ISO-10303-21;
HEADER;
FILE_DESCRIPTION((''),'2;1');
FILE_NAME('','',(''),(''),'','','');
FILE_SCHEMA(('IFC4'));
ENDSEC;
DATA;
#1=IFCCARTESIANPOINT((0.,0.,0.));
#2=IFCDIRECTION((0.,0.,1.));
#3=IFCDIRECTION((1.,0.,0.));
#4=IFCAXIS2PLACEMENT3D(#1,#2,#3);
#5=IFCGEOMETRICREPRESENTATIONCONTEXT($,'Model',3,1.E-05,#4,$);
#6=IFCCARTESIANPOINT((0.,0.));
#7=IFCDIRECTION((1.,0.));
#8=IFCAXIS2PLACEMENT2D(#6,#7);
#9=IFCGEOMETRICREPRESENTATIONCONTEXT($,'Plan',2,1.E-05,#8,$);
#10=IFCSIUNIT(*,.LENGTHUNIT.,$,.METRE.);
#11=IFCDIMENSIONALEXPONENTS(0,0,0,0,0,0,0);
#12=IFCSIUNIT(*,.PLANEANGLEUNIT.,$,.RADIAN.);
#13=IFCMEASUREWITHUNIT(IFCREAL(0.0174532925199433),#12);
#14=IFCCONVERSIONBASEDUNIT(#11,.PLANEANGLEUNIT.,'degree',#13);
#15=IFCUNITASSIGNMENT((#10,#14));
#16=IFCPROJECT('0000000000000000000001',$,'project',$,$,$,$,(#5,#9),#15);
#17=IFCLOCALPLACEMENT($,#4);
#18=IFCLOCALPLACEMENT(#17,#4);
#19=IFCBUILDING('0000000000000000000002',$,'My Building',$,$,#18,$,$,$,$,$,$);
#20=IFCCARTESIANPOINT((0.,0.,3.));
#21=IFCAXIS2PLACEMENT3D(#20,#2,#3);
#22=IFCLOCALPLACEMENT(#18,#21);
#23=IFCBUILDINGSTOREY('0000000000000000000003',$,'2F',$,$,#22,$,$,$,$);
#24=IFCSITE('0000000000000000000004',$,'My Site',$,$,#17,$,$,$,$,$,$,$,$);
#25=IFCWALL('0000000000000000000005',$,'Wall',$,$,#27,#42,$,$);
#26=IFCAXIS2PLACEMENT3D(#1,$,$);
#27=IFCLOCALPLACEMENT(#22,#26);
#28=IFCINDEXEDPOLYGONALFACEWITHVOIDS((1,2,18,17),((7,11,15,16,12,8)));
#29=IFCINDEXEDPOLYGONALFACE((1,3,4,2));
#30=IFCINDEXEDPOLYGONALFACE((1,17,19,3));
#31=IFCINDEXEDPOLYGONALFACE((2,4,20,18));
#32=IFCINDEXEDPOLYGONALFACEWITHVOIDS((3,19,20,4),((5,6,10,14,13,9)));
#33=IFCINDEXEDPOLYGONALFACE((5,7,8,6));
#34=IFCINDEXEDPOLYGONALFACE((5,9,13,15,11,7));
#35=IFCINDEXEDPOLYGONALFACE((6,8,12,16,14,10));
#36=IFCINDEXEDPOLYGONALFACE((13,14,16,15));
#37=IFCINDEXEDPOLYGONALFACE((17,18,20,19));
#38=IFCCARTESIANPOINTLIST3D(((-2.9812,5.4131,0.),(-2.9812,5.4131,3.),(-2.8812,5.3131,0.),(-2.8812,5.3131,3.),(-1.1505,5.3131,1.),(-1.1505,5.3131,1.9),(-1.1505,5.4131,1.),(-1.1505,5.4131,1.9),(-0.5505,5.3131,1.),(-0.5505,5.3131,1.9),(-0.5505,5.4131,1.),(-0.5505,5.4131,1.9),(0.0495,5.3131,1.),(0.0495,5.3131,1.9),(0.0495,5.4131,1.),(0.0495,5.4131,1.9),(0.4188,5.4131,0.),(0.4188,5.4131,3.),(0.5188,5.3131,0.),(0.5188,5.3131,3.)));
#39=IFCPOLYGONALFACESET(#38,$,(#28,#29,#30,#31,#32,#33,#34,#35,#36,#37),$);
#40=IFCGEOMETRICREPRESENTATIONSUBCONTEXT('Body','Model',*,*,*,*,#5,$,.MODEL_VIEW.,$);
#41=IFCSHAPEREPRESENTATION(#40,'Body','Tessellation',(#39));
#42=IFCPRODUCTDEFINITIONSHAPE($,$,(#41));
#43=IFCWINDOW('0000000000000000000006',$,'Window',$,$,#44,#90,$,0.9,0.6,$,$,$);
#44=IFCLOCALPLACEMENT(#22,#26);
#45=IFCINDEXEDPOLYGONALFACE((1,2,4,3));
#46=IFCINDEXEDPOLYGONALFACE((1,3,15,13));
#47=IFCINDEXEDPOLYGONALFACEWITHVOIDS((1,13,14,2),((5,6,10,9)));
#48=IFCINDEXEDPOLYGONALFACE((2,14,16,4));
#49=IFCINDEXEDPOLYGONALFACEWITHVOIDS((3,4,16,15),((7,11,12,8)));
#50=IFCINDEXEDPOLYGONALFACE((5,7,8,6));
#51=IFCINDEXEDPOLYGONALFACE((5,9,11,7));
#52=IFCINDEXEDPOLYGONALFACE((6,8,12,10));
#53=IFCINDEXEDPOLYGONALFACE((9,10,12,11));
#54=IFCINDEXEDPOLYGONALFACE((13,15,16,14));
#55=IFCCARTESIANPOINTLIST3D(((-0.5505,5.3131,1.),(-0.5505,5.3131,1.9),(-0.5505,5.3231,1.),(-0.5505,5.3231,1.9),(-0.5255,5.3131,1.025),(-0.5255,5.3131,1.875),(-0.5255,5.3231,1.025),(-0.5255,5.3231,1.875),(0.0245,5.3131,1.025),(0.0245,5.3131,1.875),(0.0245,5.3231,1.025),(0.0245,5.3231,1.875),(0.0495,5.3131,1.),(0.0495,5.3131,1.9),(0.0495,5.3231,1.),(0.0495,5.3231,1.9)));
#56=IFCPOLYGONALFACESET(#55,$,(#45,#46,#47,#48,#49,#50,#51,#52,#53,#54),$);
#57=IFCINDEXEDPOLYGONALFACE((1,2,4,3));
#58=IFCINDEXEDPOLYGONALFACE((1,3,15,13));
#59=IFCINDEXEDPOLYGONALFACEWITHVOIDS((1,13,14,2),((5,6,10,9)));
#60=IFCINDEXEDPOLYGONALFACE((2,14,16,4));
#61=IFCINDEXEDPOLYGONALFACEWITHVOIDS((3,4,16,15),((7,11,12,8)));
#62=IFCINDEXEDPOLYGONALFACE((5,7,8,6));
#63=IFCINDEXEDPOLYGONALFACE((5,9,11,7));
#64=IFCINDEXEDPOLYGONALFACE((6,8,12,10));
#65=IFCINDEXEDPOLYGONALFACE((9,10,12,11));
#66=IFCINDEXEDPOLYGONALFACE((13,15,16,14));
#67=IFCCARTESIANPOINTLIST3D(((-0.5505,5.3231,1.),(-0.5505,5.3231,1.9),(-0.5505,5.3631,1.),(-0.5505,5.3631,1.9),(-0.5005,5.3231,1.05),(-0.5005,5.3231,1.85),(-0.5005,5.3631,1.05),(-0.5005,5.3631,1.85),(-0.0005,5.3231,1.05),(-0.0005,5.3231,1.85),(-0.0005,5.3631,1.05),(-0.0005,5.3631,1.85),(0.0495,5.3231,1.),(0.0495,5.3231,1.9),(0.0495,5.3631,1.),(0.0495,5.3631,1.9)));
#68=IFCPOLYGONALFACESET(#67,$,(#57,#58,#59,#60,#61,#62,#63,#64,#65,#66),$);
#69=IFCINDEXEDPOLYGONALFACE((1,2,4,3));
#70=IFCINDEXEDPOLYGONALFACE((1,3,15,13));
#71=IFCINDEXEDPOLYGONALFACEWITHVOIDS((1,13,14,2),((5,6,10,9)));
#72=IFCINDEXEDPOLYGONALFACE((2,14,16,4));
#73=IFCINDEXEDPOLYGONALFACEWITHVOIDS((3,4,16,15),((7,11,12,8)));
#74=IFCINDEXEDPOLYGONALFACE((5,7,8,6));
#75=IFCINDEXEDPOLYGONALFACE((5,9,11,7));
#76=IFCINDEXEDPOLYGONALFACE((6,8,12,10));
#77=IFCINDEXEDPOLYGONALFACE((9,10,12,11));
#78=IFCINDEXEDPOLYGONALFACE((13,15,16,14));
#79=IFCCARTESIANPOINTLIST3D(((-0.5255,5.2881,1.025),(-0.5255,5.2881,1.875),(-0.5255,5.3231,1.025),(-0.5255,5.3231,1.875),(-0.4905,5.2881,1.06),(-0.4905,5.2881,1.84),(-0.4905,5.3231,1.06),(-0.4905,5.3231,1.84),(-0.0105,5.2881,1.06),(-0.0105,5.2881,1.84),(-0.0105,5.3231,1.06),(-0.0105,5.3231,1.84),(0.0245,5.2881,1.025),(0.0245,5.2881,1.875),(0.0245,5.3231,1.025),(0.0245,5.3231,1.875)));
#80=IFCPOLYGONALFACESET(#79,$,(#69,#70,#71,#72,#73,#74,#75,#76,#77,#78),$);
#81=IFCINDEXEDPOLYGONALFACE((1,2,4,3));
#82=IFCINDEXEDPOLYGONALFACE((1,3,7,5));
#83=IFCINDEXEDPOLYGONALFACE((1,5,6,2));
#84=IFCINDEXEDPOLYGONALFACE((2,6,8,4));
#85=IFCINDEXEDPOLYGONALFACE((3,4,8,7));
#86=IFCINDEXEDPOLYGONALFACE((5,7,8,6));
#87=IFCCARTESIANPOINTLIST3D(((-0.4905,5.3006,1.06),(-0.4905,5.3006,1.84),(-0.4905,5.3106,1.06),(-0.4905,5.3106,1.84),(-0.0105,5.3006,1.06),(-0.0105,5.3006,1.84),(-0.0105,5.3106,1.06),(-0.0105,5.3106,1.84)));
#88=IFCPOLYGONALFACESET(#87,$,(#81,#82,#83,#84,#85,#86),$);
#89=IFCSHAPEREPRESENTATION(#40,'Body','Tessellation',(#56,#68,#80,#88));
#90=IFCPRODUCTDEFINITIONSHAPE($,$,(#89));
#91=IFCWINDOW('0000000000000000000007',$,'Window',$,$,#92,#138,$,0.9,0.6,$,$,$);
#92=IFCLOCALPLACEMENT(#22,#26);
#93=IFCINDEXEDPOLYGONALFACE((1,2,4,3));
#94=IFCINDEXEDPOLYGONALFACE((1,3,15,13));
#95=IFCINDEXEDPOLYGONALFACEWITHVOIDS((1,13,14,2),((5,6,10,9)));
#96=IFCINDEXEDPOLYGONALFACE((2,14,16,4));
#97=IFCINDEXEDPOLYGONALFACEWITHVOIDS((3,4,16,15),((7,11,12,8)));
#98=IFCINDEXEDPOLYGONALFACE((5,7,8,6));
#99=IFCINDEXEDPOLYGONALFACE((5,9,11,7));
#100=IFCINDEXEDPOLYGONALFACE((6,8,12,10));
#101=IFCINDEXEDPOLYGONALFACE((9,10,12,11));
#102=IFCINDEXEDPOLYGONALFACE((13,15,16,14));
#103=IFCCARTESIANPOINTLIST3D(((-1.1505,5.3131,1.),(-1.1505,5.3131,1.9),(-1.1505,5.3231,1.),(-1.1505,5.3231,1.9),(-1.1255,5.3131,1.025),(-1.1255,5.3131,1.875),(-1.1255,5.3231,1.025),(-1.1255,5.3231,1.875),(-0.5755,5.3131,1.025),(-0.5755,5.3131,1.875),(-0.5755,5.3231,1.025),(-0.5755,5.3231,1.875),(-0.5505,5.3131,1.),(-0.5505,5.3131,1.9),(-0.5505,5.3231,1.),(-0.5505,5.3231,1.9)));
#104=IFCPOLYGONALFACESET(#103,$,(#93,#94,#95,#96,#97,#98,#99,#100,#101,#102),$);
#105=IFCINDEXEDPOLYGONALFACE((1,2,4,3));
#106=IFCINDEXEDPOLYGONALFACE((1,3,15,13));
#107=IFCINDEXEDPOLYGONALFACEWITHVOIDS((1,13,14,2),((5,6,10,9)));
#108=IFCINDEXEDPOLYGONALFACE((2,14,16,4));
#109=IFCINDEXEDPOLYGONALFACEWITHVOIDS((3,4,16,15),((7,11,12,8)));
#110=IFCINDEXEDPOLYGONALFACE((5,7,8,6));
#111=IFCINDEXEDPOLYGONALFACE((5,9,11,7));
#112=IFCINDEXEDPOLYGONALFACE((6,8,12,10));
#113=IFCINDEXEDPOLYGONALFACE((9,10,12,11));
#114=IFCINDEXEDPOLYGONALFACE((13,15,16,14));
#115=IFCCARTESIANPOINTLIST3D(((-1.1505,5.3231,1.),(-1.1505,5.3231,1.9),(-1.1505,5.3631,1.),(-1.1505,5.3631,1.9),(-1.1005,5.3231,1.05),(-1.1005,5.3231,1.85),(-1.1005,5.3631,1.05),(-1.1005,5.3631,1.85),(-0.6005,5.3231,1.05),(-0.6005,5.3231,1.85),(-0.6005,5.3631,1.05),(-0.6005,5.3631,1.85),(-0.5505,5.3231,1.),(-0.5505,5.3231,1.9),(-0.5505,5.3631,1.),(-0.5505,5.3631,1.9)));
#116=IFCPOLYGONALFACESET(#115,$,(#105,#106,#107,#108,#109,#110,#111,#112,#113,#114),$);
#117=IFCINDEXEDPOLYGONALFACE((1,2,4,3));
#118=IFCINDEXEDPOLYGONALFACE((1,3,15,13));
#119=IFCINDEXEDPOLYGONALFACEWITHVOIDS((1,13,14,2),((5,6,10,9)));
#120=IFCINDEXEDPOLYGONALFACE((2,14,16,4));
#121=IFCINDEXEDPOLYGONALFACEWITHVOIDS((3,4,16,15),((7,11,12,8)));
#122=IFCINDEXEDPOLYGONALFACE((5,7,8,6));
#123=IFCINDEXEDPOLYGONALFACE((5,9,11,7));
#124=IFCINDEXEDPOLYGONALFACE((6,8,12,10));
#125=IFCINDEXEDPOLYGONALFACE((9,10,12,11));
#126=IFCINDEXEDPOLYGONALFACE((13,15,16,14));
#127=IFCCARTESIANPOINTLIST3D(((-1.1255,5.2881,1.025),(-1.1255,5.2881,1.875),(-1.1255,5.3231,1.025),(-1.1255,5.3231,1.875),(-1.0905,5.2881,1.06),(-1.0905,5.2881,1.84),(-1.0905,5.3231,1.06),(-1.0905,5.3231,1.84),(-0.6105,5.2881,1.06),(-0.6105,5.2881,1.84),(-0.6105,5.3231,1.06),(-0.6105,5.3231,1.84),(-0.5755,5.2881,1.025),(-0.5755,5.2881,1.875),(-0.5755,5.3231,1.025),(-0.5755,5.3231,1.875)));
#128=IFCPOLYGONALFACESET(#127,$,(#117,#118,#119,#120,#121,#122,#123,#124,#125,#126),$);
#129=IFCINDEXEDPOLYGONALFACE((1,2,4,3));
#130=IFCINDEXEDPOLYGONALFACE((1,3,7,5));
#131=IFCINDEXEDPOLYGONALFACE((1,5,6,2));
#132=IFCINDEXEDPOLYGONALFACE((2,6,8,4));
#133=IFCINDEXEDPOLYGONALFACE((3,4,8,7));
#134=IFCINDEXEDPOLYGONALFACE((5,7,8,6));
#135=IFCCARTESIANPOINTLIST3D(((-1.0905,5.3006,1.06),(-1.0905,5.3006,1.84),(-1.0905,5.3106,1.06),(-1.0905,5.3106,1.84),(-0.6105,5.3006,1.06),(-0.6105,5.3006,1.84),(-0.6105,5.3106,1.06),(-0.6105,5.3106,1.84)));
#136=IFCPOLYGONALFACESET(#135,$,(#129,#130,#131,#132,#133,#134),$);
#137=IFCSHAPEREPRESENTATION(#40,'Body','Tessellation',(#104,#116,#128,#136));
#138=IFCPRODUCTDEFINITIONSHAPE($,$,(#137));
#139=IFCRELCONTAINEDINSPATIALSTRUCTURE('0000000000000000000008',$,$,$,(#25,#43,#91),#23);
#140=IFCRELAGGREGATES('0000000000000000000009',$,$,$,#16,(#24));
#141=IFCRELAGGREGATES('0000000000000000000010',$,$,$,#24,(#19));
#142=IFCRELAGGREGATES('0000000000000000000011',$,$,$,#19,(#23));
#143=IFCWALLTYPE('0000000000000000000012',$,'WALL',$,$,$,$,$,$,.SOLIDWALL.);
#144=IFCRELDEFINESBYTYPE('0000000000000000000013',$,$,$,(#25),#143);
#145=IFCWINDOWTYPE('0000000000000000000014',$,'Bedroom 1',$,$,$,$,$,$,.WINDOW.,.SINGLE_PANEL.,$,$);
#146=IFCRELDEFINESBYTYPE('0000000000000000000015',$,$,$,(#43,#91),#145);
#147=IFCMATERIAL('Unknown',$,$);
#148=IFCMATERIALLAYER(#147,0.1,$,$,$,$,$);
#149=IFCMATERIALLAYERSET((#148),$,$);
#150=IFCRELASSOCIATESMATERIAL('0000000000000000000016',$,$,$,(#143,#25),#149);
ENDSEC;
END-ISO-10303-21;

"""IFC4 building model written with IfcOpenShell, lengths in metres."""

from ifc_helpers import new_model, entity, si_unit, converted_unit, frame, origin_with_axes, origin_2d_with_axis, place, context, subcontext, project, spatial, line, indexed_curve, outline, extrude, shape, source, transform, mapped, material, layer, layer_set, layer_usage, type_object, type_shapes, element, fill, save


model = new_model("IFC4")

# Units and contexts
model_context = context("Model", 3, precision=1e-05, world=origin_with_axes())
plan_context = context("Plan", 2, precision=1e-05, world=origin_2d_with_axis())
body_context_1 = subcontext(model_context, "Body", "Model", "MODEL_VIEW")
body_context_2 = subcontext(plan_context, "Body", "Plan", "PLAN_VIEW")
ifc_project = project(units=[si_unit("LENGTHUNIT", "METRE"), converted_unit("PLANEANGLEUNIT", "degree", entity("IfcReal", 0.0174532925199433), si_unit("PLANEANGLEUNIT", "RADIAN"), dimensions=[0, 0, 0, 0, 0, 0, 0])], contexts=[model_context, plan_context])

# Site, building, storey
site_placement = place(None, origin_with_axes())
site = spatial("IfcSite", under=ifc_project, at=site_placement, Name="My Site")
building_placement = place(site_placement, origin_with_axes())
building = spatial("IfcBuilding", under=site, at=building_placement, Name="My Building")
storey_placement = place(building_placement, frame((0.0, 0.0, 3.0), z_axis=(0.0, 0.0, 1.0), x_axis=(1.0, 0.0, 0.0)))
storey = spatial("IfcBuildingStorey", under=building, at=storey_placement, Name="2F")

# Shared definitions
ifc_material = material(Name="Unknown")

# Shared definitions
ifc_layer_1 = layer(ifc_material, 0.1)
ifc_layer_set_1 = layer_set([ifc_layer_1])
wall_type = type_object("IfcWallType", Name="WALL", PredefinedType="SOLIDWALL", material=ifc_layer_set_1)

# Wall, openings, windows
ifc_layer_usage_1 = layer_usage(ifc_layer_set_1, "AXIS2", "POSITIVE", 0.0)
wall_1_placement = place(storey_placement, frame((0.4188, 5.4131, 0.0), z_axis=(0.0, 0.0, 1.0), x_axis=(-1.0, 0.0, 0.0)))
wall_1 = element("IfcWall", 1, at=wall_1_placement, inside=storey, type_object=wall_type, material=ifc_layer_usage_1, Name="Wall", context=body_context_1, shape_type="SweptSolid", body=[
    extrude(outline(indexed_curve([(0.0, 0.0), (-0.1, 0.1), (3.3, 0.1), (3.4, 0.0)], segments=[line(1, 2, 3, 4, 1)])), origin_with_axes(), (0.0, 0.0, 1.0), 3.0),
])
shared_shape_1 = source(origin_with_axes(), body_context_1, "Body", "SweptSolid", [
    extrude(outline(indexed_curve([(0.0, 0.0), (0.6, 0.0), (0.6, 0.9), (0.0, 0.9)], segments=[line(1, 2, 3, 4, 1)])), frame((0.0, -0.6, 0.0), z_axis=(0.0, -1.0, 0.0), x_axis=(1.0, 0.0, 0.0)), (0.0, 0.0, -1.0), 1.2),
])
opening_1_placement = place(wall_1_placement, frame((0.3694, 0.0, 1.0), z_axis=(0.0, 0.0, 1.0), x_axis=(1.0, 0.0, 0.0)))
opening_1 = element("IfcOpeningElement", 2, at=opening_1_placement, cuts=wall_1, PredefinedType="OPENING", context=body_context_1, shape_type="MappedRepresentation", body=[
    mapped(shared_shape_1, transform((0.0, 0.0, 0.0), x_axis=(1.0, 0.0, 0.0), y_axis=(0.0, 1.0, 0.0), z_axis=(0.0, 0.0, 1.0), scale=1.0)),
])
opening_2_placement = place(wall_1_placement, frame((0.9694, 0.0, 1.0), z_axis=(0.0, 0.0, 1.0), x_axis=(1.0, 0.0, 0.0)))
opening_2 = element("IfcOpeningElement", 3, at=opening_2_placement, cuts=wall_1, PredefinedType="OPENING", context=body_context_1, shape_type="MappedRepresentation", body=[
    mapped(shared_shape_1, transform((0.0, 0.0, 0.0), x_axis=(1.0, 0.0, 0.0), y_axis=(0.0, 1.0, 0.0), z_axis=(0.0, 0.0, 1.0), scale=1.0)),
])
window_type_1 = type_object("IfcWindowType", Name="Bedroom 1", PartitioningType="SINGLE_PANEL", PredefinedType="WINDOW")
shared_shape_2 = source(origin_with_axes(), body_context_1, "Body", "SweptSolid", [
    extrude(outline(indexed_curve([(0.0, 0.0), (0.6, 0.0), (0.6, 0.9), (0.0, 0.9)], segments=[line(1, 2, 3, 4, 1)]), holes=[indexed_curve([(0.025, 0.025), (0.575, 0.025), (0.575, 0.875), (0.025, 0.875)], segments=[line(1, 2, 3, 4, 1)])]), frame((0.0, 0.09, 0.0), z_axis=(0.0, -1.0, 0.0), x_axis=(1.0, 0.0, 0.0)), (0.0, 0.0, -1.0), 0.01),
    extrude(outline(indexed_curve([(0.0, 0.0), (0.6, 0.0), (0.6, 0.9), (0.0, 0.9)], segments=[line(1, 2, 3, 4, 1)]), holes=[indexed_curve([(0.05, 0.05), (0.55, 0.05), (0.55, 0.85), (0.05, 0.85)], segments=[line(1, 2, 3, 4, 1)])]), frame((0.0, 0.05, 0.0), z_axis=(0.0, -1.0, 0.0), x_axis=(1.0, 0.0, 0.0)), (0.0, 0.0, -1.0), 0.04),
    extrude(outline(indexed_curve([(0.0, 0.0), (0.55, 0.0), (0.55, 0.85), (0.0, 0.85)], segments=[line(1, 2, 3, 4, 1)]), holes=[indexed_curve([(0.035, 0.035), (0.515, 0.035), (0.515, 0.815), (0.035, 0.815)], segments=[line(1, 2, 3, 4, 1)])]), frame((0.025, 0.09, 0.025), z_axis=(0.0, -1.0, 0.0), x_axis=(1.0, 0.0, 0.0)), (0.0, 0.0, -1.0), 0.035),
    extrude(outline(indexed_curve([(0.035, 0.035), (0.515, 0.035), (0.515, 0.815), (0.035, 0.815)], segments=[line(1, 2, 3, 4, 1)])), frame((0.025, 0.1025, 0.025), z_axis=(0.0, -1.0, 0.0), x_axis=(1.0, 0.0, 0.0)), (0.0, 0.0, -1.0), 0.01),
])
shared_shape_3 = source(origin_with_axes(), body_context_2, "Body", "Curve2D", [
    entity("IfcIndexedPolyCurve", entity("IfcCartesianPointList2D", [[0.05, 0.05], [0.55, 0.05]])),
    entity("IfcIndexedPolyCurve", entity("IfcCartesianPointList2D", [[0.0, 0.1], [0.025, 0.1], [0.025, 0.09], [0.05, 0.09], [0.05, 0.05], [0.0, 0.05]]), [entity("IfcLineIndex", [1, 2, 3, 4, 5, 6, 1])]),
    entity("IfcIndexedPolyCurve", entity("IfcCartesianPointList2D", [[0.6, 0.1], [0.575, 0.1], [0.575, 0.09], [0.55, 0.09], [0.55, 0.05], [0.6, 0.05]]), [entity("IfcLineIndex", [1, 2, 3, 4, 5, 6, 1])]),
    entity("IfcIndexedPolyCurve", entity("IfcCartesianPointList2D", [[0.025, 0.09], [0.06, 0.09], [0.06, 0.125], [0.025, 0.125]]), [entity("IfcLineIndex", [1, 2, 3, 4, 1])]),
    entity("IfcIndexedPolyCurve", entity("IfcCartesianPointList2D", [[0.575, 0.09], [0.54, 0.09], [0.54, 0.125], [0.575, 0.125]]), [entity("IfcLineIndex", [1, 2, 3, 4, 1])]),
    entity("IfcIndexedPolyCurve", entity("IfcCartesianPointList2D", [[0.06, 0.09], [0.54, 0.09]])),
    entity("IfcIndexedPolyCurve", entity("IfcCartesianPointList2D", [[0.06, 0.125], [0.54, 0.125]])),
    entity("IfcIndexedPolyCurve", entity("IfcCartesianPointList2D", [[0.06, 0.1075], [0.54, 0.1075]])),
])
type_shapes(window_type_1, [shared_shape_2, shared_shape_3])
window_1_placement = place(opening_1_placement, frame((0.0, 0.0, 0.0), z_axis=(0.0, 0.0, 1.0), x_axis=(1.0, 0.0, 0.0)))
window_1 = element("IfcWindow", 4, at=window_1_placement, inside=storey, type_object=window_type_1, Name="Window", OverallHeight=0.9, OverallWidth=0.6, shapes=[
    shape(body_context_1, "Body", "MappedRepresentation", [mapped(shared_shape_2, transform((0.0, 0.0, 0.0), x_axis=(1.0, 0.0, 0.0), y_axis=(0.0, 1.0, 0.0), z_axis=(0.0, 0.0, 1.0), scale=1.0))]),
    shape(body_context_2, "Body", "MappedRepresentation", [mapped(shared_shape_3, transform((0.0, 0.0, 0.0), x_axis=(1.0, 0.0, 0.0), y_axis=(0.0, 1.0, 0.0), z_axis=(0.0, 0.0, 1.0), scale=1.0))]),
])
fill(opening_1, window_1)
window_2_placement = place(opening_2_placement, origin_with_axes())
window_2 = element("IfcWindow", 5, at=window_2_placement, inside=storey, type_object=window_type_1, Name="Window", OverallHeight=0.9, OverallWidth=0.6, shapes=[
    shape(body_context_1, "Body", "MappedRepresentation", [mapped(shared_shape_2, transform((0.0, 0.0, 0.0), x_axis=(1.0, 0.0, 0.0), y_axis=(0.0, 1.0, 0.0), z_axis=(0.0, 0.0, 1.0), scale=1.0))]),
    shape(body_context_2, "Body", "MappedRepresentation", [mapped(shared_shape_3, transform((0.0, 0.0, 0.0), x_axis=(1.0, 0.0, 0.0), y_axis=(0.0, 1.0, 0.0), z_axis=(0.0, 0.0, 1.0), scale=1.0))]),
])
fill(opening_2, window_2)

save(model, "model.ifc")
